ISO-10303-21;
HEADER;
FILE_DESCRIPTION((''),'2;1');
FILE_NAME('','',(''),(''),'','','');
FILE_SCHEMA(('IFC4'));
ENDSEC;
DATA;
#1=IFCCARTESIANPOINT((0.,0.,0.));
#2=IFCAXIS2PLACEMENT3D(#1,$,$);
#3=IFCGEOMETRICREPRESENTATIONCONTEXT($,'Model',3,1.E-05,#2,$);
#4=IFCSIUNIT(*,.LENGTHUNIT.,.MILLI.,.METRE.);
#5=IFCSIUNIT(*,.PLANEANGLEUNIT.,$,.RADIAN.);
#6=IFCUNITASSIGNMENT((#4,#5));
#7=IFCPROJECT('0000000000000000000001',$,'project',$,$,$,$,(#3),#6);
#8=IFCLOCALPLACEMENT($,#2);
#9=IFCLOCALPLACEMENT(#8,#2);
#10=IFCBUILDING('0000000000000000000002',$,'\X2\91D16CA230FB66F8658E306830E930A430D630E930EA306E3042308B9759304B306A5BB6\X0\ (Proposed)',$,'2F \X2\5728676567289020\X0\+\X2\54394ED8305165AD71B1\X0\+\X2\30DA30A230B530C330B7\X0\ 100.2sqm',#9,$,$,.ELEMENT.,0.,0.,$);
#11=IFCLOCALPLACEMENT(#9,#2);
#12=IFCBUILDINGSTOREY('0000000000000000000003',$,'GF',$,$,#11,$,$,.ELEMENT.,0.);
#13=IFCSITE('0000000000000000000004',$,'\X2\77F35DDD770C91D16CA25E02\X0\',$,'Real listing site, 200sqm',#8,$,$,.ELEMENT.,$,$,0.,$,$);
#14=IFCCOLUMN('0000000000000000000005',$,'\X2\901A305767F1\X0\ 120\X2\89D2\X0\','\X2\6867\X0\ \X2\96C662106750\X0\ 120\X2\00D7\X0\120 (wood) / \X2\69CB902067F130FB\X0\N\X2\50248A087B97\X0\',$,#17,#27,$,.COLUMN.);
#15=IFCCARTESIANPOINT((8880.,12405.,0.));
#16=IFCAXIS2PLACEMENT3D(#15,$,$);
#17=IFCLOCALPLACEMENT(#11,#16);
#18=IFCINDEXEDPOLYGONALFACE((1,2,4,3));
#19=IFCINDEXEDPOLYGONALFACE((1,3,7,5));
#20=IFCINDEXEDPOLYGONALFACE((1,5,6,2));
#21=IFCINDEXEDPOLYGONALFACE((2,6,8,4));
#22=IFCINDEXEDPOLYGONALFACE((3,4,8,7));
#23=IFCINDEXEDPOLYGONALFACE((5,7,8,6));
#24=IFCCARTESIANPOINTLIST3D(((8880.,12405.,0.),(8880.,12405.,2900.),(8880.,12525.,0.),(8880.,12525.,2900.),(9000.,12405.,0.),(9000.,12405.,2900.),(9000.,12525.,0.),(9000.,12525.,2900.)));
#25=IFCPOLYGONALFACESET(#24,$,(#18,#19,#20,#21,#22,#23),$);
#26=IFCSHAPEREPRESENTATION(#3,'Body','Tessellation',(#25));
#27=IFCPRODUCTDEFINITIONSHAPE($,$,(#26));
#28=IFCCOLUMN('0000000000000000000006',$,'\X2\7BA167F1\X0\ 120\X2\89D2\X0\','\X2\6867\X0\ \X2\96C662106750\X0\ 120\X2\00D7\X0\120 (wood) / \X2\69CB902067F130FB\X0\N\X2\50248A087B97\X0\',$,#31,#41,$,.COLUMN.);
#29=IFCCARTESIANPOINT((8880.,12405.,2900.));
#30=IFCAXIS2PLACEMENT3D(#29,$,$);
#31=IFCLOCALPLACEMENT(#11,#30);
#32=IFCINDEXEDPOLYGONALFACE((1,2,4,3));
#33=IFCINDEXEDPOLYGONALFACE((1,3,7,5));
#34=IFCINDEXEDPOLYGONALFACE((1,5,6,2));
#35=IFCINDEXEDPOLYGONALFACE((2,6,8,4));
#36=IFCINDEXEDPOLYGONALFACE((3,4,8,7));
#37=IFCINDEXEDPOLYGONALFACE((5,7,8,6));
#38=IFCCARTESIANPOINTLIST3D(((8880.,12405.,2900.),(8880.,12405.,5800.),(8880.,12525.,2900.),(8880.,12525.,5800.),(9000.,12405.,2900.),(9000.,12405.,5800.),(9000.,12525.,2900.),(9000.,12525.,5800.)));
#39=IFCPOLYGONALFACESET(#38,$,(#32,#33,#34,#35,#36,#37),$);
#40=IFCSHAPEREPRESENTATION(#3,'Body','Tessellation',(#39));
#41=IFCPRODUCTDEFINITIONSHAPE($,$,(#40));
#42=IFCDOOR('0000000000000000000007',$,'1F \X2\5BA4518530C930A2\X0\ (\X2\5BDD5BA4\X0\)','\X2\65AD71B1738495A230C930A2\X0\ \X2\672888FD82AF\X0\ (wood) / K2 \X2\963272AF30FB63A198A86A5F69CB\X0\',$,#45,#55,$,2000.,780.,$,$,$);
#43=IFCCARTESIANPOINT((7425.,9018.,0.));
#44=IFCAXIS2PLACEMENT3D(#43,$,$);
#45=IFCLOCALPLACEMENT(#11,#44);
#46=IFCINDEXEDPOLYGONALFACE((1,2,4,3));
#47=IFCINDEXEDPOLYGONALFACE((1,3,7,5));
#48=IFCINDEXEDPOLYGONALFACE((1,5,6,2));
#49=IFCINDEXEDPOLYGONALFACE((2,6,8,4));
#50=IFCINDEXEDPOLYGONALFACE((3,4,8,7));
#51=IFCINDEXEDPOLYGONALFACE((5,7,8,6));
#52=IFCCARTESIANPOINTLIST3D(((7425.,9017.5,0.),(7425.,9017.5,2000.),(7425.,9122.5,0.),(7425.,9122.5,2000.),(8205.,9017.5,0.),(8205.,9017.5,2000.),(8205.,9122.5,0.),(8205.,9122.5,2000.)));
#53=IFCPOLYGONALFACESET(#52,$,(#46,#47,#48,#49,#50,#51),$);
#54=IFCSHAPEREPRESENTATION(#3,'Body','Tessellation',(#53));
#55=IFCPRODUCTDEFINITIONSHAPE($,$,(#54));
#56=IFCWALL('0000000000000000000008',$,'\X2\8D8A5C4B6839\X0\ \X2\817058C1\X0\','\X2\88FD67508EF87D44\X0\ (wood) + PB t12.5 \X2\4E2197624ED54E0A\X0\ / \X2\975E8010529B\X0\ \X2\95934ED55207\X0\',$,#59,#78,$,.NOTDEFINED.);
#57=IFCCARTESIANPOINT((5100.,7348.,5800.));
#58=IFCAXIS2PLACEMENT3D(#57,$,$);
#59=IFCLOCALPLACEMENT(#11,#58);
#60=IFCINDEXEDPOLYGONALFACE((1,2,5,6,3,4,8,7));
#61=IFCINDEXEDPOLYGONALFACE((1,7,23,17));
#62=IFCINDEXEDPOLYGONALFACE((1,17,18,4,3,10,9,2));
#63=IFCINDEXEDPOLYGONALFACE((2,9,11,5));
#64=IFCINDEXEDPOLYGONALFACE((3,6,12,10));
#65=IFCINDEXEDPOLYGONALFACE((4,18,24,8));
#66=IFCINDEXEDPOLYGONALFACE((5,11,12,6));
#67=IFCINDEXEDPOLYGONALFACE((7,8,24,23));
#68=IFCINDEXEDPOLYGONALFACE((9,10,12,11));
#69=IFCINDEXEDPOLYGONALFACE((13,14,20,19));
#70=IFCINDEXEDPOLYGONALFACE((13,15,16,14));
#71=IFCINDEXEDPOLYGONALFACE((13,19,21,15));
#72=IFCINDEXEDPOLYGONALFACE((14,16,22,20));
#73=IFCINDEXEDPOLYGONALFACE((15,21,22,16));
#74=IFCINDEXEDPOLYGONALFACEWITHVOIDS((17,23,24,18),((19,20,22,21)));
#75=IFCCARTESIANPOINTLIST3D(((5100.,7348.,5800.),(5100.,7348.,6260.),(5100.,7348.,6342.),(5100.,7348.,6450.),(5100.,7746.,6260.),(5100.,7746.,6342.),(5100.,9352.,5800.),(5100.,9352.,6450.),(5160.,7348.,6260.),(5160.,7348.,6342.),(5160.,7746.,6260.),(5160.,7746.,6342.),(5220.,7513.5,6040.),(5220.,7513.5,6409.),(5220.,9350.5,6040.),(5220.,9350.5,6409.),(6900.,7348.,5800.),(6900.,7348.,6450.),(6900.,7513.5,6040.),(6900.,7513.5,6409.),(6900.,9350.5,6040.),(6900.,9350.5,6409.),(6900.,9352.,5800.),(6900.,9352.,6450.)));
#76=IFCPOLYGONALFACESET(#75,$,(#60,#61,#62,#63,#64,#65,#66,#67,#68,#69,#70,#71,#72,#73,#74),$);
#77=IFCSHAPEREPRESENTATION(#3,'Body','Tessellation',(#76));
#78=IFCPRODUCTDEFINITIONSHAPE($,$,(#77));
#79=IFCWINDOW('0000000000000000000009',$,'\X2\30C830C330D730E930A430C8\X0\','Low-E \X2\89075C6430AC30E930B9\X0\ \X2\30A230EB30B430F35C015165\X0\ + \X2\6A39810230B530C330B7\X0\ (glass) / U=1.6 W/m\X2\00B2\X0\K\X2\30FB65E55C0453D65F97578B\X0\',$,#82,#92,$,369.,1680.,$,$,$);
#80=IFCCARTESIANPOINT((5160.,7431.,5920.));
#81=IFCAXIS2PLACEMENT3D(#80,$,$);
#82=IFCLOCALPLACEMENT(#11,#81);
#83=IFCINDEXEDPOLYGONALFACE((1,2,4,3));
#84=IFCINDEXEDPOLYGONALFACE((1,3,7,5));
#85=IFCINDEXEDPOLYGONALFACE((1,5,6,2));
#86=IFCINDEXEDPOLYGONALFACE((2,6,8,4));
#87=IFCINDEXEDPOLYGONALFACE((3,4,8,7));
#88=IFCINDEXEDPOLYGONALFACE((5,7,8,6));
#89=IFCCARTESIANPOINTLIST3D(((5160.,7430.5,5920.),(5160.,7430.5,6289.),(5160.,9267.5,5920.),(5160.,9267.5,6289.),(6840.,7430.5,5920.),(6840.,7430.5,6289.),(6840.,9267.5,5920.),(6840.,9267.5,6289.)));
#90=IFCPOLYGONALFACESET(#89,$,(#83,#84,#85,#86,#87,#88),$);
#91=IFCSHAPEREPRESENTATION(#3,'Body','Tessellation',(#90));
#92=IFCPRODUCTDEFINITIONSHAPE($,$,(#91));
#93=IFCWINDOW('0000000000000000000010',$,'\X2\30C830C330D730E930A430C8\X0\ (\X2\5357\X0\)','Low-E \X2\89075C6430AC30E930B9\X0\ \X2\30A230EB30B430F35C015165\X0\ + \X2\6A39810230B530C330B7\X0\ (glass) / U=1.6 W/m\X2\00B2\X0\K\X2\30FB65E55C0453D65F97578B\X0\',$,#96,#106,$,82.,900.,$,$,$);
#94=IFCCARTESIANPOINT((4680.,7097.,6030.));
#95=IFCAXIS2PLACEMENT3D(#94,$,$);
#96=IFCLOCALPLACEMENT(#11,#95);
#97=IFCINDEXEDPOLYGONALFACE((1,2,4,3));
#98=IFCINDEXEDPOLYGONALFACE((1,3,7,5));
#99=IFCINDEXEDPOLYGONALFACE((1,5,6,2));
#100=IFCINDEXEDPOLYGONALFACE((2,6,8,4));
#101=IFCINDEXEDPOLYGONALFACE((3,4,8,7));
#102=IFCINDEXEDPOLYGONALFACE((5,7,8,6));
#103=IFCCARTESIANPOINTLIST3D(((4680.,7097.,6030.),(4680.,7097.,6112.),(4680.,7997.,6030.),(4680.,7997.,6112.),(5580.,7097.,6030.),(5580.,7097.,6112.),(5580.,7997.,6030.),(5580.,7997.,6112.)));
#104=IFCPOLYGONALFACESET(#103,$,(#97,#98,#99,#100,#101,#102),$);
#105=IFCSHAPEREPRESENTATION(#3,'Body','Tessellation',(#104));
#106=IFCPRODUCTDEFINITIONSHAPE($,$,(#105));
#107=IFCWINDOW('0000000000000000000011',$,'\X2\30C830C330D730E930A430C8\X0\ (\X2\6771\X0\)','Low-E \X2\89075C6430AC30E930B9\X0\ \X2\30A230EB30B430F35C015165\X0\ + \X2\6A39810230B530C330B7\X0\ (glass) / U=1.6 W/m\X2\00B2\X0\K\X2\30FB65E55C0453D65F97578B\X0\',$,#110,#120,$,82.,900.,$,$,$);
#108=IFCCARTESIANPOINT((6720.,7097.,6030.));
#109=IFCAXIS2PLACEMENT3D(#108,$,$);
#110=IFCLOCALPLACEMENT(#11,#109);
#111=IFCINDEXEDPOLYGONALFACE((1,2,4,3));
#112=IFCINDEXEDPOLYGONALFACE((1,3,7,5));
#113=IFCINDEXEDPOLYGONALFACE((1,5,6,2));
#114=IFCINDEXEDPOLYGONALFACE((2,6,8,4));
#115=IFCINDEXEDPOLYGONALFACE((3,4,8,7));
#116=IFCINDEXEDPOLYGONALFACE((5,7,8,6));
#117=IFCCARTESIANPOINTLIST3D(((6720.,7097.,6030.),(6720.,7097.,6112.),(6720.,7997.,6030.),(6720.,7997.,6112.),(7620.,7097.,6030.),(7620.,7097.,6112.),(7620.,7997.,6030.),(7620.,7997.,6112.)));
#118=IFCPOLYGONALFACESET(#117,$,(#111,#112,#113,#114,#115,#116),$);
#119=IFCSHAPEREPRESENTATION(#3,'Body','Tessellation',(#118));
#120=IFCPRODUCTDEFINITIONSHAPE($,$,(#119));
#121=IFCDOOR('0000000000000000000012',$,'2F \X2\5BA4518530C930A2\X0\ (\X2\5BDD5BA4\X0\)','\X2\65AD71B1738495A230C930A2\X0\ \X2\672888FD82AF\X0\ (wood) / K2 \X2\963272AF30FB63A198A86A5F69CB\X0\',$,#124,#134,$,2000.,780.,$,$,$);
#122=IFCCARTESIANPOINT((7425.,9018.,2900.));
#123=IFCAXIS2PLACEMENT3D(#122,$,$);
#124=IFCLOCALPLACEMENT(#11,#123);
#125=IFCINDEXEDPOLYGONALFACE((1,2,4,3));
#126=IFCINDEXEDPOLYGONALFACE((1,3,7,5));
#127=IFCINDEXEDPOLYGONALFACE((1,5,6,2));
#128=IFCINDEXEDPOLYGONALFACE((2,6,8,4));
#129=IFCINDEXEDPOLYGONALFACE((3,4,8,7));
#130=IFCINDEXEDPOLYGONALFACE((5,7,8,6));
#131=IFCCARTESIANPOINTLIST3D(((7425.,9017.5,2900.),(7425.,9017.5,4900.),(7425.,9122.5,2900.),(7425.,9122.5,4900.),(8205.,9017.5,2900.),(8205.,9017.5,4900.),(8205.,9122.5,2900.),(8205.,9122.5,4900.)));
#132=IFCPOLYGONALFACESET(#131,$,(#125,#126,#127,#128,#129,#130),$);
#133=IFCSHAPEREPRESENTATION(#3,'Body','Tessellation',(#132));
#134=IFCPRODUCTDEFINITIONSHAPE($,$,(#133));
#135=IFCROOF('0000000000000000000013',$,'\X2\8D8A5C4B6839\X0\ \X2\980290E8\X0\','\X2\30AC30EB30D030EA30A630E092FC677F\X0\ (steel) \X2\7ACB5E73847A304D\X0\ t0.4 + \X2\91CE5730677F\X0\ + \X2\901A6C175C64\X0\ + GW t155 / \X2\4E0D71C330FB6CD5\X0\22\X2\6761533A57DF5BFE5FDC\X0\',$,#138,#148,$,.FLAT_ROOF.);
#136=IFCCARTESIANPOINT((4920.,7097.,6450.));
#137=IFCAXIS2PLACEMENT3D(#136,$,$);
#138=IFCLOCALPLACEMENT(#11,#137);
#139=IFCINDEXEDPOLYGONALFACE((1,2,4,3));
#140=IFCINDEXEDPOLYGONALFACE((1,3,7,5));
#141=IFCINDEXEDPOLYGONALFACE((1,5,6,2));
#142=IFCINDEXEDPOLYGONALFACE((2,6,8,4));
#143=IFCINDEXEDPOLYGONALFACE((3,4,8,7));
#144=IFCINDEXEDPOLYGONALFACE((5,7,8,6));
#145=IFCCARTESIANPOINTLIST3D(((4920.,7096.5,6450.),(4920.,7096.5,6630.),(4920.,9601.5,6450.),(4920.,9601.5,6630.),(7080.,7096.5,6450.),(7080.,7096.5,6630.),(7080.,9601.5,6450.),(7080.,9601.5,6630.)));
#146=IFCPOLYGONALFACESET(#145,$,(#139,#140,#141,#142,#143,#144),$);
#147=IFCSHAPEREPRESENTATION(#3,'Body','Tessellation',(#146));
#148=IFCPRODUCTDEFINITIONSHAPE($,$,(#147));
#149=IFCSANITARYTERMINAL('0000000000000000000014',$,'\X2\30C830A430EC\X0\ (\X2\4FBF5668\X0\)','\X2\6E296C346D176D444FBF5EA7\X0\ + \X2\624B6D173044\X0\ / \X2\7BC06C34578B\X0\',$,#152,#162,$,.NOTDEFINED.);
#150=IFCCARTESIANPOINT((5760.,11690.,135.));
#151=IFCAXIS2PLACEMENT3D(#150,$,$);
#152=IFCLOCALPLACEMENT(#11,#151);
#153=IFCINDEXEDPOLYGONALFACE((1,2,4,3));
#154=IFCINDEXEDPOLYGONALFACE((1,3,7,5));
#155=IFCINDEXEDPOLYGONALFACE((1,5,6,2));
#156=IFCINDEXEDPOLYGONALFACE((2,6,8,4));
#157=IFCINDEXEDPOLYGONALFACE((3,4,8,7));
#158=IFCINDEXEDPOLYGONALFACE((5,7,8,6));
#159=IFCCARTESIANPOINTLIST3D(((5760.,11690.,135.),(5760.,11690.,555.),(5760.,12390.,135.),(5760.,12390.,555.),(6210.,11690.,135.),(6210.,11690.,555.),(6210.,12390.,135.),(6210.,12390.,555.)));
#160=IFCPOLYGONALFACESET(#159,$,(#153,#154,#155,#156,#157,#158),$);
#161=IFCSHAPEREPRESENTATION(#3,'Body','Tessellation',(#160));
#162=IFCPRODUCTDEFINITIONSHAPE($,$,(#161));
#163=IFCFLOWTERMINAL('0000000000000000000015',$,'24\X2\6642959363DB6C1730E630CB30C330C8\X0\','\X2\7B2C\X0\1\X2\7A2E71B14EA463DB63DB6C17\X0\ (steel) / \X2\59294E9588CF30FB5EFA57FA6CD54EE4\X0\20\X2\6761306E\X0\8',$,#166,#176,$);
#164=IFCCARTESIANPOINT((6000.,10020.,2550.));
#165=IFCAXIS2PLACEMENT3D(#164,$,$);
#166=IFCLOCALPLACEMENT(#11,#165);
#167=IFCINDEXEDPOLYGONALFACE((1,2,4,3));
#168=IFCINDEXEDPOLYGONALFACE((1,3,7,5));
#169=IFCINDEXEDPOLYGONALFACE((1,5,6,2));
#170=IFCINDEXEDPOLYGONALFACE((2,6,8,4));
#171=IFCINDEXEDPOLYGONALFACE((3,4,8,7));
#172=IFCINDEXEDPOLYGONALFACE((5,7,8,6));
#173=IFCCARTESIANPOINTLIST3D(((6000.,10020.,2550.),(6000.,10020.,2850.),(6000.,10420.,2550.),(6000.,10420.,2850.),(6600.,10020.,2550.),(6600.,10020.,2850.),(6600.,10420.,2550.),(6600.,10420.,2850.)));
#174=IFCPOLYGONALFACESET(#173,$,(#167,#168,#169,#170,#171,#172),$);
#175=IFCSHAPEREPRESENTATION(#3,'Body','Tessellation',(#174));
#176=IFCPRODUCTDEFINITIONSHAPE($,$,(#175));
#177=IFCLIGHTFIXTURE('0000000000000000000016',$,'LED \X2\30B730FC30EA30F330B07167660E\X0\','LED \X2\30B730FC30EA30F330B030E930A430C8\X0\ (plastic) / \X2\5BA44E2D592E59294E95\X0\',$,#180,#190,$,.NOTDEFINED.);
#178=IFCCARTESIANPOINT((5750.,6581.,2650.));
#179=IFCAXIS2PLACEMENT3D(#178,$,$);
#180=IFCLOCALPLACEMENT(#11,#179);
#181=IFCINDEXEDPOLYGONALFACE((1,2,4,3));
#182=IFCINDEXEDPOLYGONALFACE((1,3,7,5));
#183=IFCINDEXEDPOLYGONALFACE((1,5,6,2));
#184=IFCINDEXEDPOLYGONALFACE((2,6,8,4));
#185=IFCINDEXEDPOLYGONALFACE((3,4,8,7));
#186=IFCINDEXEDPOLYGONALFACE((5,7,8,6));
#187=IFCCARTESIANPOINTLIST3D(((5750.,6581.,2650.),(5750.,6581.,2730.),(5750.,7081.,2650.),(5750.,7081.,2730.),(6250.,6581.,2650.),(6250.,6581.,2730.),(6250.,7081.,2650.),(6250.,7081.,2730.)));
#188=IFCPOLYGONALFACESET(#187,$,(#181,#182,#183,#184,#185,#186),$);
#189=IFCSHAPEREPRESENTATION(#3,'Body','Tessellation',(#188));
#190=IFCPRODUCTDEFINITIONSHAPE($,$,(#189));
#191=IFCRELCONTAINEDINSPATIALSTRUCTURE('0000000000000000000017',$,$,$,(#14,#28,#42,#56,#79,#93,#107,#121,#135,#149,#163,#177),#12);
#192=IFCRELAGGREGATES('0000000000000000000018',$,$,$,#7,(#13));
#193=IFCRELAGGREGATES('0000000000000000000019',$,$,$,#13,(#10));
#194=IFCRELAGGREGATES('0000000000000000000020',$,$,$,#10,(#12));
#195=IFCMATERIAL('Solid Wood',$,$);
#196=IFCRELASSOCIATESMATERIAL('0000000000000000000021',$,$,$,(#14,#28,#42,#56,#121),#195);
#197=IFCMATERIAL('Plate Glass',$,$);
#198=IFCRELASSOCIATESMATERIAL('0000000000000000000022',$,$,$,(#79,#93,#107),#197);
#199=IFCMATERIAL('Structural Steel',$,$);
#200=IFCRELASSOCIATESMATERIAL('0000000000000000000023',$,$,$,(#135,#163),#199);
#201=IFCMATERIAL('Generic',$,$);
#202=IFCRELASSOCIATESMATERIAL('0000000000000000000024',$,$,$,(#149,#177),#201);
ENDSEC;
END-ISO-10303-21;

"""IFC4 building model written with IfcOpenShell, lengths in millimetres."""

from ifc_helpers import new_model, si_unit, frame, frame_2d, origin, place, context, project, spatial, rectangle, extrude, material, element, fill, save


model = new_model("IFC4")

# Units and contexts
model_context = context("Model", 3, precision=1e-05, world=origin())
ifc_project = project(units=[si_unit("LENGTHUNIT", "METRE", prefix="MILLI"), si_unit("PLANEANGLEUNIT", "RADIAN")], contexts=[model_context])

# Site, building, storey
site_placement = place(None, origin())
site = spatial("IfcSite", under=ifc_project, at=site_placement, Name="石川県金沢市", ObjectType="Real listing site, 200sqm", CompositionType="ELEMENT", RefElevation=0.0)
building_placement = place(site_placement, origin())
building = spatial("IfcBuilding", under=site, at=building_placement, Name="金沢・書斎とライブラリのある静かな家 (Proposed)", ObjectType="2F 在来木造+吹付け断熱+ペアサッシ 100.2sqm", CompositionType="ELEMENT", ElevationOfRefHeight=0.0, ElevationOfTerrain=0.0)
storey_placement = place(building_placement, origin())
storey = spatial("IfcBuildingStorey", under=building, at=storey_placement, Name="GF", CompositionType="ELEMENT", Elevation=0.0)

# Columns
ifc_material_1 = material(Name="Solid Wood")
column_1_placement = place(storey_placement, frame((8880.0, 12405.0, 0.0)))
element("IfcColumn", 1, at=column_1_placement, inside=storey, material=ifc_material_1, Name="通し柱 120角", Description="桧 集成材 120×120 (wood) / 構造柱・N値計算", PredefinedType="COLUMN", context=model_context, shape_type="SweptSolid", body=[
    extrude(rectangle(XDim=120.0, YDim=120.0, at=frame_2d((60.0, 60.0))), frame((8880.0, 12405.0, 0.0)), (0.0, 0.0, 1.0), 2900.0),
])
column_2_placement = place(storey_placement, frame((8880.0, 12405.0, 2900.0)))
element("IfcColumn", 2, at=column_2_placement, inside=storey, material=ifc_material_1, Name="管柱 120角", Description="桧 集成材 120×120 (wood) / 構造柱・N値計算", PredefinedType="COLUMN", context=model_context, shape_type="SweptSolid", body=[
    extrude(rectangle(XDim=120.0, YDim=120.0, at=frame_2d((60.0, 60.0))), frame((8880.0, 12405.0, 2900.0)), (0.0, 0.0, 1.0), 2900.0),
])

# Door
door_1_placement = place(storey_placement, frame((7425.0, 9018.0, 0.0)))
element("IfcDoor", 3, at=door_1_placement, inside=storey, material=ifc_material_1, Name="1F 室内ドア (寝室)", Description="断熱玄関ドア 木製芯 (wood) / K2 防犯・採風機構", OverallHeight=2000.0, OverallWidth=780.0, context=model_context, shape_type="SweptSolid", body=[
    extrude(rectangle(XDim=780.0, YDim=105.0, at=frame_2d((390.0, 52.0))), frame((7425.0, 9018.0, 0.0)), (0.0, 0.0, 1.0), 2000.0),
])

# Wall, openings, windows
wall_1_placement = place(storey_placement, frame((5100.0, 7348.0, 5800.0)))
wall_1 = element("IfcWall", 4, at=wall_1_placement, inside=storey, material=ifc_material_1, Name="越屋根 腰壁", Description="製材軸組 (wood) + PB t12.5 両面仕上 / 非耐力 間仕切", PredefinedType="NOTDEFINED", context=model_context, shape_type="SweptSolid", body=[
    extrude(rectangle(XDim=1800.0, YDim=2004.0, at=frame_2d((900.0, 1002.0))), frame((5100.0, 7348.0, 5800.0)), (0.0, 0.0, 1.0), 650.0),
])
opening_1_placement = place(storey_placement, frame((5160.0, 7431.0, 5920.0)))
opening_1 = element("IfcOpeningElement", 5, at=opening_1_placement, cuts=wall_1, PredefinedType="NOTDEFINED", context=model_context, shape_type="SweptSolid", body=[
    extrude(rectangle(XDim=1680.0, YDim=1837.0, at=frame_2d((840.0, 918.0))), frame((5160.0, 7431.0, 5920.0)), (0.0, 0.0, 1.0), 369.0),
])
opening_2_placement = place(storey_placement, frame((4680.0, 7097.0, 6030.0)))
opening_2 = element("IfcOpeningElement", 6, at=opening_2_placement, cuts=wall_1, PredefinedType="NOTDEFINED", context=model_context, shape_type="SweptSolid", body=[
    extrude(rectangle(XDim=900.0, YDim=900.0, at=frame_2d((450.0, 450.0))), frame((4680.0, 7097.0, 6030.0)), (0.0, 0.0, 1.0), 82.0),
])
opening_3_placement = place(storey_placement, frame((6720.0, 7097.0, 6030.0)))
opening_3 = element("IfcOpeningElement", 7, at=opening_3_placement, cuts=wall_1, PredefinedType="NOTDEFINED", context=model_context, shape_type="SweptSolid", body=[
    extrude(rectangle(XDim=900.0, YDim=900.0, at=frame_2d((450.0, 450.0))), frame((6720.0, 7097.0, 6030.0)), (0.0, 0.0, 1.0), 82.0),
])
ifc_material_2 = material(Name="Plate Glass")
window_1_placement = place(storey_placement, frame((5160.0, 7431.0, 5920.0)))
window_1 = element("IfcWindow", 8, at=window_1_placement, inside=storey, material=ifc_material_2, Name="トップライト", Description="Low-E 複層ガラス アルゴン封入 + 樹脂サッシ (glass) / U=1.6 W/m²K・日射取得型", OverallHeight=369.0, OverallWidth=1680.0, context=model_context, shape_type="SweptSolid", body=[
    extrude(rectangle(XDim=1680.0, YDim=1837.0, at=frame_2d((840.0, 918.0))), frame((5160.0, 7431.0, 5920.0)), (0.0, 0.0, 1.0), 369.0),
])
fill(opening_1, window_1)
window_2_placement = place(storey_placement, frame((4680.0, 7097.0, 6030.0)))
window_2 = element("IfcWindow", 9, at=window_2_placement, inside=storey, material=ifc_material_2, Name="トップライト (南)", Description="Low-E 複層ガラス アルゴン封入 + 樹脂サッシ (glass) / U=1.6 W/m²K・日射取得型", OverallHeight=82.0, OverallWidth=900.0, context=model_context, shape_type="SweptSolid", body=[
    extrude(rectangle(XDim=900.0, YDim=900.0, at=frame_2d((450.0, 450.0))), frame((4680.0, 7097.0, 6030.0)), (0.0, 0.0, 1.0), 82.0),
])
fill(opening_2, window_2)
window_3_placement = place(storey_placement, frame((6720.0, 7097.0, 6030.0)))
window_3 = element("IfcWindow", 10, at=window_3_placement, inside=storey, material=ifc_material_2, Name="トップライト (東)", Description="Low-E 複層ガラス アルゴン封入 + 樹脂サッシ (glass) / U=1.6 W/m²K・日射取得型", OverallHeight=82.0, OverallWidth=900.0, context=model_context, shape_type="SweptSolid", body=[
    extrude(rectangle(XDim=900.0, YDim=900.0, at=frame_2d((450.0, 450.0))), frame((6720.0, 7097.0, 6030.0)), (0.0, 0.0, 1.0), 82.0),
])
fill(opening_3, window_3)

# Door
door_2_placement = place(storey_placement, frame((7425.0, 9018.0, 2900.0)))
element("IfcDoor", 11, at=door_2_placement, inside=storey, material=ifc_material_1, Name="2F 室内ドア (寝室)", Description="断熱玄関ドア 木製芯 (wood) / K2 防犯・採風機構", OverallHeight=2000.0, OverallWidth=780.0, context=model_context, shape_type="SweptSolid", body=[
    extrude(rectangle(XDim=780.0, YDim=105.0, at=frame_2d((390.0, 52.0))), frame((7425.0, 9018.0, 2900.0)), (0.0, 0.0, 1.0), 2000.0),
])

# Roof
ifc_material_3 = material(Name="Structural Steel")
roof_placement = place(storey_placement, frame((4920.0, 7097.0, 6450.0)))
element("IfcRoof", 12, at=roof_placement, inside=storey, material=ifc_material_3, Name="越屋根 頂部", Description="ガルバリウム鋼板 (steel) 立平葺き t0.4 + 野地板 + 通気層 + GW t155 / 不燃・法22条区域対応", PredefinedType="FLAT_ROOF", context=model_context, shape_type="SweptSolid", body=[
    extrude(rectangle(XDim=2160.0, YDim=2505.0, at=frame_2d((1080.0, 1252.0))), frame((4920.0, 7097.0, 6450.0)), (0.0, 0.0, 1.0), 180.0),
])

# Sanitary terminal
ifc_material_4 = material(Name="Generic")
sanitary_terminal_placement = place(storey_placement, frame((5760.0, 11690.0, 135.0)))
element("IfcSanitaryTerminal", 13, at=sanitary_terminal_placement, inside=storey, material=ifc_material_4, Name="トイレ (便器)", Description="温水洗浄便座 + 手洗い / 節水型", PredefinedType="NOTDEFINED", context=model_context, shape_type="SweptSolid", body=[
    extrude(rectangle(XDim=450.0, YDim=700.0, at=frame_2d((225.0, 350.0))), frame((5760.0, 11690.0, 135.0)), (0.0, 0.0, 1.0), 420.0),
])

# Flow terminal
flow_terminal_placement = place(storey_placement, frame((6000.0, 10020.0, 2550.0)))
element("IfcFlowTerminal", 14, at=flow_terminal_placement, inside=storey, material=ifc_material_3, Name="24時間換気ユニット", Description="第1種熱交換換気 (steel) / 天井裏・建基法令20条の8", context=model_context, shape_type="SweptSolid", body=[
    extrude(rectangle(XDim=600.0, YDim=400.0, at=frame_2d((300.0, 200.0))), frame((6000.0, 10020.0, 2550.0)), (0.0, 0.0, 1.0), 300.0),
])

# Light fixture
light_fixture_1_placement = place(storey_placement, frame((5750.0, 6581.0, 2650.0)))
element("IfcLightFixture", 15, at=light_fixture_1_placement, inside=storey, material=ifc_material_4, Name="LED シーリング照明", Description="LED シーリングライト (plastic) / 室中央天井", PredefinedType="NOTDEFINED", context=model_context, shape_type="SweptSolid", body=[
    extrude(rectangle(XDim=500.0, YDim=500.0, at=frame_2d((250.0, 250.0))), frame((5750.0, 6581.0, 2650.0)), (0.0, 0.0, 1.0), 80.0),
])

save(model, "model.ifc")
